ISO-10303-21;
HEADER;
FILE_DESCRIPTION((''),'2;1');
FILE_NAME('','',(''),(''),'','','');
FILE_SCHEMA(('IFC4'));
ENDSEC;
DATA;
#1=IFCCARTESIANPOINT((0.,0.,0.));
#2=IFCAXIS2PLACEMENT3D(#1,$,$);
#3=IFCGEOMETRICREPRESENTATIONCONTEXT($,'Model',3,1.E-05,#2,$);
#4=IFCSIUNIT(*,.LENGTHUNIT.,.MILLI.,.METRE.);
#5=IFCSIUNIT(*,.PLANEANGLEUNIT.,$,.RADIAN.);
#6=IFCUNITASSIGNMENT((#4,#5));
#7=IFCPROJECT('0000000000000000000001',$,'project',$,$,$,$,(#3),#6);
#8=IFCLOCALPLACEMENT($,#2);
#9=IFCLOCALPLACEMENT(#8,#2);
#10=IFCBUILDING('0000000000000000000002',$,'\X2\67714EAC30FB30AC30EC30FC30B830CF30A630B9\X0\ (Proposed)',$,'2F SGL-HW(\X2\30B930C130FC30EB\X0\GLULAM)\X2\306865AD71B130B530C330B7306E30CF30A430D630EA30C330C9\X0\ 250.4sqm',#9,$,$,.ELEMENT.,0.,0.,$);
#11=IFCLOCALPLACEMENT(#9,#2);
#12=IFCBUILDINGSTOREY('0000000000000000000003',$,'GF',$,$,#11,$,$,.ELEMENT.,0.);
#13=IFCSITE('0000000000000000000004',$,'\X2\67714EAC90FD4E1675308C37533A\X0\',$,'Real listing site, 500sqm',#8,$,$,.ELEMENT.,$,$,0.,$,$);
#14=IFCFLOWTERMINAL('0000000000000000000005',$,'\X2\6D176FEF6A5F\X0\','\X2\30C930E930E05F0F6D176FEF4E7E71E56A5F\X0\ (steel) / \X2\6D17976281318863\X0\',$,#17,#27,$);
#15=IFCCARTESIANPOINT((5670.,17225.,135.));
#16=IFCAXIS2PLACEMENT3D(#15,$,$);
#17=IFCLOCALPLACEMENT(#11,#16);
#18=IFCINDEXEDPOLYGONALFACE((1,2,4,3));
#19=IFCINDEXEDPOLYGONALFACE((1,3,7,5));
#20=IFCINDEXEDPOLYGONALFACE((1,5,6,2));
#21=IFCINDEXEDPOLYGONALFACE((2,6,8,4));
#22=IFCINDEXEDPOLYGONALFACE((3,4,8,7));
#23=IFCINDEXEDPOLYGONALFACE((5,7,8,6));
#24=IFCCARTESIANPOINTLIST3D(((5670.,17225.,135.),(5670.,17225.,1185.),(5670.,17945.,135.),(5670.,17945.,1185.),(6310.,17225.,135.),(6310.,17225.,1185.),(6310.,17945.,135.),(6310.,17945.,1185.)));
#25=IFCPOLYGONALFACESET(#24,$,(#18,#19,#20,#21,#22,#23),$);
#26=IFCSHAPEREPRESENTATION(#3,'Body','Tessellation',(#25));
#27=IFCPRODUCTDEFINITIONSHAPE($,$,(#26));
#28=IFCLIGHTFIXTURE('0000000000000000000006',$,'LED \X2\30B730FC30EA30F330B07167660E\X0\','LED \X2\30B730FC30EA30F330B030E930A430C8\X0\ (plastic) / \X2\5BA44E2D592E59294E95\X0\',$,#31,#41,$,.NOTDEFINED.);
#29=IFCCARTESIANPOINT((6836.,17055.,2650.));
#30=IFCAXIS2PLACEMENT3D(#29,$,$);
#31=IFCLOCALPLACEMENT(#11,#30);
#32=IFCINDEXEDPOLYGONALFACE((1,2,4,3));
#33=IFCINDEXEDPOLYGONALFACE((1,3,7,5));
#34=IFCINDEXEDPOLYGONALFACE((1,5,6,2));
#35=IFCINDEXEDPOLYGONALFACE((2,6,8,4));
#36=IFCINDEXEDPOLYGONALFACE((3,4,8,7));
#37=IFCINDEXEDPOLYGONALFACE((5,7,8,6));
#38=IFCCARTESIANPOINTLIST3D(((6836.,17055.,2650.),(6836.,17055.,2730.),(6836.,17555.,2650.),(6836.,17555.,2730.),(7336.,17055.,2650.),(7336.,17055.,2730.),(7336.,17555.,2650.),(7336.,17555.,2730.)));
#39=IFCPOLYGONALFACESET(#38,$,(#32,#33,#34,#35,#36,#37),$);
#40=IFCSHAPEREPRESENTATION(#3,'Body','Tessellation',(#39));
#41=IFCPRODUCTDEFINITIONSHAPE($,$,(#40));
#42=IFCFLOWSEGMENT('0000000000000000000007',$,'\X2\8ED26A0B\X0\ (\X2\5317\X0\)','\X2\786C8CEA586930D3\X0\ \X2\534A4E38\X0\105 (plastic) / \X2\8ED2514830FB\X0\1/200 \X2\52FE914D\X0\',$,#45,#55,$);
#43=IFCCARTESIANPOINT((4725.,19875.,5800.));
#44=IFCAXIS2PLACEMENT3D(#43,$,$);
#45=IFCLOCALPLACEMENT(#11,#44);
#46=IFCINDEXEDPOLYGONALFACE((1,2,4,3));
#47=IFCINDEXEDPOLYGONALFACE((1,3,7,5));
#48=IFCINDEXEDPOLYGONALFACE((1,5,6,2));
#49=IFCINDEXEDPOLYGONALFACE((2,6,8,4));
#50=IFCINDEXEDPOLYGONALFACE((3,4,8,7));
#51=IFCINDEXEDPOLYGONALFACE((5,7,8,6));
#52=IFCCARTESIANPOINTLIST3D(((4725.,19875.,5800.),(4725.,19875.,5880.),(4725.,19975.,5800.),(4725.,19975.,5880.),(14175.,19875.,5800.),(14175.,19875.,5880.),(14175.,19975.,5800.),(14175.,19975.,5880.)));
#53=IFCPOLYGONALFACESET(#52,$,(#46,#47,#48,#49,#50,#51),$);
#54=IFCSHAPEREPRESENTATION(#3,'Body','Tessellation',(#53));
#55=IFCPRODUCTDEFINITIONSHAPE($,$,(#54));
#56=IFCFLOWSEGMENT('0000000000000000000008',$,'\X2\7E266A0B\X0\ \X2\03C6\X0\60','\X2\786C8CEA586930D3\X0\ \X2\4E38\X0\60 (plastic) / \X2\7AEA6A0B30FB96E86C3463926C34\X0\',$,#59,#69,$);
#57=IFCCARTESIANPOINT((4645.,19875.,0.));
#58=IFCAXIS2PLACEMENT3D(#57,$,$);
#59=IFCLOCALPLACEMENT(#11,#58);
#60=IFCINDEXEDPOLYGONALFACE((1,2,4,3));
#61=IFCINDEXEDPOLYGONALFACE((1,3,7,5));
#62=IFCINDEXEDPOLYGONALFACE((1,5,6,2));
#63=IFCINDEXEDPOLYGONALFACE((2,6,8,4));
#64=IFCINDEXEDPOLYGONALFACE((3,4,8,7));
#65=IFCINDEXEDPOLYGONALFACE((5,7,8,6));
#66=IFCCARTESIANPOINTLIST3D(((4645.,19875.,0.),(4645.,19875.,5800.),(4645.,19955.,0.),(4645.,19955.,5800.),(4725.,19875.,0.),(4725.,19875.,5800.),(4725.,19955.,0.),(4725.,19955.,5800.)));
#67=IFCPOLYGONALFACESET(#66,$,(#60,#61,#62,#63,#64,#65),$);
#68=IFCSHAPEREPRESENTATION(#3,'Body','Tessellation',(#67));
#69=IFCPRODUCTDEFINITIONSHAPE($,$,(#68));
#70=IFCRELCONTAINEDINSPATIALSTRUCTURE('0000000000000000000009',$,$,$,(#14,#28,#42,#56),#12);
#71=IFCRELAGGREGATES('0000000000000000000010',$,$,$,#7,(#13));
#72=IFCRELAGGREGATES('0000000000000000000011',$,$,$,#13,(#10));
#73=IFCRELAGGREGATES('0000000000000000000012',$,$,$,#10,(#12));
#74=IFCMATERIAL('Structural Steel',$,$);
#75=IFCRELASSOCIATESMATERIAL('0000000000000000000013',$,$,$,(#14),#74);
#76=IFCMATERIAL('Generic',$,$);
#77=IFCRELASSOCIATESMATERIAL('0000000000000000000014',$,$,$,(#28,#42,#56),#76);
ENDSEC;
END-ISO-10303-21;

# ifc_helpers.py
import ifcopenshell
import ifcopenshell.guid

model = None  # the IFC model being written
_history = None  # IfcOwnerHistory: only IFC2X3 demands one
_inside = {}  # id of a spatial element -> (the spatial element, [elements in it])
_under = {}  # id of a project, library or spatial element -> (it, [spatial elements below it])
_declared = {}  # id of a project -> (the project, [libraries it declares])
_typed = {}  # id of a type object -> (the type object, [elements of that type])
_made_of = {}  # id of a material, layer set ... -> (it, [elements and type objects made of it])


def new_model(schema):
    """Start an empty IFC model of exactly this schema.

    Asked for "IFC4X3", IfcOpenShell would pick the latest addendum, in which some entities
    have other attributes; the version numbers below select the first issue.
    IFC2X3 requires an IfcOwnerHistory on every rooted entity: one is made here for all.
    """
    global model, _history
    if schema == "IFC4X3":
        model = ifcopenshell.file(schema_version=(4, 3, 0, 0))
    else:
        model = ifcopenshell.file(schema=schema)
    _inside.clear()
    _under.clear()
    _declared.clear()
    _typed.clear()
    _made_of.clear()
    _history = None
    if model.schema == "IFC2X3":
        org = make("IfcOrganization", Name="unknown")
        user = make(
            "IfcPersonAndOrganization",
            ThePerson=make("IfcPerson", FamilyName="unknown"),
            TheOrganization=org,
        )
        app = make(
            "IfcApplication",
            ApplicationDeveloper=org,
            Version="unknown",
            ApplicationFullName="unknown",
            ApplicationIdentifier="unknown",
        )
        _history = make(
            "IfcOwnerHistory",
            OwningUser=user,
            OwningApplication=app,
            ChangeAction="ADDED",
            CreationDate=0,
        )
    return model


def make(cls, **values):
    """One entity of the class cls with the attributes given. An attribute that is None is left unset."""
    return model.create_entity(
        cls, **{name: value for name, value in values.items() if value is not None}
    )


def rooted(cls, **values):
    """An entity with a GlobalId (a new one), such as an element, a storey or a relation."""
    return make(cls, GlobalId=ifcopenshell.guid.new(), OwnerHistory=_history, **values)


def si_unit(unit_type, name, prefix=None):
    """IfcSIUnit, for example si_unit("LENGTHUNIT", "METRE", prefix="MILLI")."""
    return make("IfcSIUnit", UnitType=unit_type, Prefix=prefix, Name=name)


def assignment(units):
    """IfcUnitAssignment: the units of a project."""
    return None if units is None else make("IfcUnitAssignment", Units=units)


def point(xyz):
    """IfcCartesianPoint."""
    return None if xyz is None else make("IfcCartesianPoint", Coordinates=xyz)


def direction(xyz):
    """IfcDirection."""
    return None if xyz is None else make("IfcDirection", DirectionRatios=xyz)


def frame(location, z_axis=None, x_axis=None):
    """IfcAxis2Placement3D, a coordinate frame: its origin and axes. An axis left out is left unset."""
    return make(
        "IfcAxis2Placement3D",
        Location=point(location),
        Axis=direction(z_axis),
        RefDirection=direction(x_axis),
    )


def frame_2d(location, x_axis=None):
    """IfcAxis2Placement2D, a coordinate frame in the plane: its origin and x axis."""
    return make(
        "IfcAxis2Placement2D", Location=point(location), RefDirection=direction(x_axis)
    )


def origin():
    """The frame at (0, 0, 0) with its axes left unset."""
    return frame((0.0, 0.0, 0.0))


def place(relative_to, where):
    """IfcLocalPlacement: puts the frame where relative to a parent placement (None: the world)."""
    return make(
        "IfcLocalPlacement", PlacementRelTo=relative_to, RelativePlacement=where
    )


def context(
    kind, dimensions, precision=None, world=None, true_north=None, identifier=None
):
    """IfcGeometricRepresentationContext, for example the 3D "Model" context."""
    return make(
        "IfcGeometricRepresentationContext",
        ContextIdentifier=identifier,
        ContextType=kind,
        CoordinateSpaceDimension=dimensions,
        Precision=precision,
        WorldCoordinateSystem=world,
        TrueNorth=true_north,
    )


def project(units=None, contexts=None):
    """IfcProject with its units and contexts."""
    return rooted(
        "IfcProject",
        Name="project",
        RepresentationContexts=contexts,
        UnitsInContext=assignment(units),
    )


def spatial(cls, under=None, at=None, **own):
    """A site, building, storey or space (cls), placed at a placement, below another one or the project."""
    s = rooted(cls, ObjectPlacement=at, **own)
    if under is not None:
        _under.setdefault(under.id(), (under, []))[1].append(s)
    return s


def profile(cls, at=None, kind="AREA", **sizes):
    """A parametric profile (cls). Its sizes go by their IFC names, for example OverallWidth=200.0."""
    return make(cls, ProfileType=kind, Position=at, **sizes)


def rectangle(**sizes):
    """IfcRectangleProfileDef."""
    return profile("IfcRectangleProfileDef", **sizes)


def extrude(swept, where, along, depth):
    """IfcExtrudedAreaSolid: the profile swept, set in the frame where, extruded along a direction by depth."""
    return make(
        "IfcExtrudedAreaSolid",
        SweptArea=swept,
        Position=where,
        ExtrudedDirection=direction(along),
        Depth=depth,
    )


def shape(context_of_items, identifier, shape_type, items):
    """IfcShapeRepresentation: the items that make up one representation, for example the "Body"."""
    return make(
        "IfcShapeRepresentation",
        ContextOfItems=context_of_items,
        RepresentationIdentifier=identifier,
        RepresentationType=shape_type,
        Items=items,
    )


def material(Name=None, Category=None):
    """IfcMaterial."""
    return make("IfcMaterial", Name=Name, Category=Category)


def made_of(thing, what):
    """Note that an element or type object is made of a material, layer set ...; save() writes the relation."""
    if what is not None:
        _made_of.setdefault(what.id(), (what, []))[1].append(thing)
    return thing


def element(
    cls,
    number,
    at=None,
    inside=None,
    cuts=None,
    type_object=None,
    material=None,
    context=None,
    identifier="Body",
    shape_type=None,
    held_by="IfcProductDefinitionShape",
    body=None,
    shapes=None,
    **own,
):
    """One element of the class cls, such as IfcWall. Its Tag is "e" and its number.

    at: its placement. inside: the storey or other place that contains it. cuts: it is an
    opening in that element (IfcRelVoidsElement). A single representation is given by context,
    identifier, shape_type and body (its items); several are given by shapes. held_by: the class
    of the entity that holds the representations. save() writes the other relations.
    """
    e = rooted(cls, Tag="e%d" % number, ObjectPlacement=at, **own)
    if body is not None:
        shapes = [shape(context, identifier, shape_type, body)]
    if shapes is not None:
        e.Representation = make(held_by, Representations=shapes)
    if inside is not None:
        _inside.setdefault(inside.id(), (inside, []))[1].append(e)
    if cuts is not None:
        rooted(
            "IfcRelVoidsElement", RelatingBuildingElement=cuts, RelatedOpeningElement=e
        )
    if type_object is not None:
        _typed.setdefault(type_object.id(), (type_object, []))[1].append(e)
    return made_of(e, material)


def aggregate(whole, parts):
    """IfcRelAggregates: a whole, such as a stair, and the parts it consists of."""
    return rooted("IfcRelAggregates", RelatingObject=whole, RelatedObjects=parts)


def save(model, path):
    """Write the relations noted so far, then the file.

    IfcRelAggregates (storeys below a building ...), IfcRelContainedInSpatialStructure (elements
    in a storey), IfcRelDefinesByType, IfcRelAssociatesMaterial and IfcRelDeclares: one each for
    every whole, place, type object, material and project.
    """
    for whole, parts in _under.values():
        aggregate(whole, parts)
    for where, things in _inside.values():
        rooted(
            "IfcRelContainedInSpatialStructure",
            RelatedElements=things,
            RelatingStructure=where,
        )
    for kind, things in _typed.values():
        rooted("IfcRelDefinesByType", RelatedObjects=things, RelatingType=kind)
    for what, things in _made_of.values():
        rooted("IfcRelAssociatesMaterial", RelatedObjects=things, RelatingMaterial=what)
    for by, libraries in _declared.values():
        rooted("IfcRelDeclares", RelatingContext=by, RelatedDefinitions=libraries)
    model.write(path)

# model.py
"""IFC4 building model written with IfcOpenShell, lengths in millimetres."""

from ifc_helpers import new_model, si_unit, frame, frame_2d, origin, place, context, project, spatial, rectangle, extrude, material, element, save


model = new_model("IFC4")

# Units and contexts
model_context = context("Model", 3, precision=1e-05, world=origin())
ifc_project = project(units=[si_unit("LENGTHUNIT", "METRE", prefix="MILLI"), si_unit("PLANEANGLEUNIT", "RADIAN")], contexts=[model_context])

# Site, building, storey
site_placement = place(None, origin())
site = spatial("IfcSite", under=ifc_project, at=site_placement, Name="東京都世田谷区", ObjectType="Real listing site, 500sqm", CompositionType="ELEMENT", RefElevation=0.0)
building_placement = place(site_placement, origin())
building = spatial("IfcBuilding", under=site, at=building_placement, Name="東京・ガレージハウス (Proposed)", ObjectType="2F SGL-HW(スチールGLULAM)と断熱サッシのハイブリッド 250.4sqm", CompositionType="ELEMENT", ElevationOfRefHeight=0.0, ElevationOfTerrain=0.0)
storey_placement = place(building_placement, origin())
storey = spatial("IfcBuildingStorey", under=building, at=storey_placement, Name="GF", CompositionType="ELEMENT", Elevation=0.0)

# Flow terminal
ifc_material_1 = material(Name="Structural Steel")
flow_terminal_placement = place(storey_placement, frame((5670.0, 17225.0, 135.0)))
element("IfcFlowTerminal", 1, at=flow_terminal_placement, inside=storey, material=ifc_material_1, Name="洗濯機", Description="ドラム式洗濯乾燥機 (steel) / 洗面脱衣", context=model_context, shape_type="SweptSolid", body=[
    extrude(rectangle(XDim=640.0, YDim=720.0, at=frame_2d((320.0, 360.0))), frame((5670.0, 17225.0, 135.0)), (0.0, 0.0, 1.0), 1050.0),
])

# Light fixture
ifc_material_2 = material(Name="Generic")
light_fixture_placement = place(storey_placement, frame((6836.0, 17055.0, 2650.0)))
element("IfcLightFixture", 2, at=light_fixture_placement, inside=storey, material=ifc_material_2, Name="LED シーリング照明", Description="LED シーリングライト (plastic) / 室中央天井", PredefinedType="NOTDEFINED", context=model_context, shape_type="SweptSolid", body=[
    extrude(rectangle(XDim=500.0, YDim=500.0, at=frame_2d((250.0, 250.0))), frame((6836.0, 17055.0, 2650.0)), (0.0, 0.0, 1.0), 80.0),
])

# Flow segments
flow_segment_1_placement = place(storey_placement, frame((4725.0, 19875.0, 5800.0)))
element("IfcFlowSegment", 3, at=flow_segment_1_placement, inside=storey, material=ifc_material_2, Name="軒樋 (北)", Description="硬質塩ビ 半丸105 (plastic) / 軒先・1/200 勾配", context=model_context, shape_type="SweptSolid", body=[
    extrude(rectangle(XDim=9450.0, YDim=100.0, at=frame_2d((4725.0, 50.0))), frame((4725.0, 19875.0, 5800.0)), (0.0, 0.0, 1.0), 80.0),
])
flow_segment_2_placement = place(storey_placement, frame((4645.0, 19875.0, 0.0)))
element("IfcFlowSegment", 4, at=flow_segment_2_placement, inside=storey, material=ifc_material_2, Name="縦樋 φ60", Description="硬質塩ビ 丸60 (plastic) / 竪樋・雨水排水", context=model_context, shape_type="SweptSolid", body=[
    extrude(rectangle(XDim=80.0, YDim=80.0, at=frame_2d((40.0, 40.0))), frame((4645.0, 19875.0, 0.0)), (0.0, 0.0, 1.0), 5800.0),
])

save(model, "model.ifc")
